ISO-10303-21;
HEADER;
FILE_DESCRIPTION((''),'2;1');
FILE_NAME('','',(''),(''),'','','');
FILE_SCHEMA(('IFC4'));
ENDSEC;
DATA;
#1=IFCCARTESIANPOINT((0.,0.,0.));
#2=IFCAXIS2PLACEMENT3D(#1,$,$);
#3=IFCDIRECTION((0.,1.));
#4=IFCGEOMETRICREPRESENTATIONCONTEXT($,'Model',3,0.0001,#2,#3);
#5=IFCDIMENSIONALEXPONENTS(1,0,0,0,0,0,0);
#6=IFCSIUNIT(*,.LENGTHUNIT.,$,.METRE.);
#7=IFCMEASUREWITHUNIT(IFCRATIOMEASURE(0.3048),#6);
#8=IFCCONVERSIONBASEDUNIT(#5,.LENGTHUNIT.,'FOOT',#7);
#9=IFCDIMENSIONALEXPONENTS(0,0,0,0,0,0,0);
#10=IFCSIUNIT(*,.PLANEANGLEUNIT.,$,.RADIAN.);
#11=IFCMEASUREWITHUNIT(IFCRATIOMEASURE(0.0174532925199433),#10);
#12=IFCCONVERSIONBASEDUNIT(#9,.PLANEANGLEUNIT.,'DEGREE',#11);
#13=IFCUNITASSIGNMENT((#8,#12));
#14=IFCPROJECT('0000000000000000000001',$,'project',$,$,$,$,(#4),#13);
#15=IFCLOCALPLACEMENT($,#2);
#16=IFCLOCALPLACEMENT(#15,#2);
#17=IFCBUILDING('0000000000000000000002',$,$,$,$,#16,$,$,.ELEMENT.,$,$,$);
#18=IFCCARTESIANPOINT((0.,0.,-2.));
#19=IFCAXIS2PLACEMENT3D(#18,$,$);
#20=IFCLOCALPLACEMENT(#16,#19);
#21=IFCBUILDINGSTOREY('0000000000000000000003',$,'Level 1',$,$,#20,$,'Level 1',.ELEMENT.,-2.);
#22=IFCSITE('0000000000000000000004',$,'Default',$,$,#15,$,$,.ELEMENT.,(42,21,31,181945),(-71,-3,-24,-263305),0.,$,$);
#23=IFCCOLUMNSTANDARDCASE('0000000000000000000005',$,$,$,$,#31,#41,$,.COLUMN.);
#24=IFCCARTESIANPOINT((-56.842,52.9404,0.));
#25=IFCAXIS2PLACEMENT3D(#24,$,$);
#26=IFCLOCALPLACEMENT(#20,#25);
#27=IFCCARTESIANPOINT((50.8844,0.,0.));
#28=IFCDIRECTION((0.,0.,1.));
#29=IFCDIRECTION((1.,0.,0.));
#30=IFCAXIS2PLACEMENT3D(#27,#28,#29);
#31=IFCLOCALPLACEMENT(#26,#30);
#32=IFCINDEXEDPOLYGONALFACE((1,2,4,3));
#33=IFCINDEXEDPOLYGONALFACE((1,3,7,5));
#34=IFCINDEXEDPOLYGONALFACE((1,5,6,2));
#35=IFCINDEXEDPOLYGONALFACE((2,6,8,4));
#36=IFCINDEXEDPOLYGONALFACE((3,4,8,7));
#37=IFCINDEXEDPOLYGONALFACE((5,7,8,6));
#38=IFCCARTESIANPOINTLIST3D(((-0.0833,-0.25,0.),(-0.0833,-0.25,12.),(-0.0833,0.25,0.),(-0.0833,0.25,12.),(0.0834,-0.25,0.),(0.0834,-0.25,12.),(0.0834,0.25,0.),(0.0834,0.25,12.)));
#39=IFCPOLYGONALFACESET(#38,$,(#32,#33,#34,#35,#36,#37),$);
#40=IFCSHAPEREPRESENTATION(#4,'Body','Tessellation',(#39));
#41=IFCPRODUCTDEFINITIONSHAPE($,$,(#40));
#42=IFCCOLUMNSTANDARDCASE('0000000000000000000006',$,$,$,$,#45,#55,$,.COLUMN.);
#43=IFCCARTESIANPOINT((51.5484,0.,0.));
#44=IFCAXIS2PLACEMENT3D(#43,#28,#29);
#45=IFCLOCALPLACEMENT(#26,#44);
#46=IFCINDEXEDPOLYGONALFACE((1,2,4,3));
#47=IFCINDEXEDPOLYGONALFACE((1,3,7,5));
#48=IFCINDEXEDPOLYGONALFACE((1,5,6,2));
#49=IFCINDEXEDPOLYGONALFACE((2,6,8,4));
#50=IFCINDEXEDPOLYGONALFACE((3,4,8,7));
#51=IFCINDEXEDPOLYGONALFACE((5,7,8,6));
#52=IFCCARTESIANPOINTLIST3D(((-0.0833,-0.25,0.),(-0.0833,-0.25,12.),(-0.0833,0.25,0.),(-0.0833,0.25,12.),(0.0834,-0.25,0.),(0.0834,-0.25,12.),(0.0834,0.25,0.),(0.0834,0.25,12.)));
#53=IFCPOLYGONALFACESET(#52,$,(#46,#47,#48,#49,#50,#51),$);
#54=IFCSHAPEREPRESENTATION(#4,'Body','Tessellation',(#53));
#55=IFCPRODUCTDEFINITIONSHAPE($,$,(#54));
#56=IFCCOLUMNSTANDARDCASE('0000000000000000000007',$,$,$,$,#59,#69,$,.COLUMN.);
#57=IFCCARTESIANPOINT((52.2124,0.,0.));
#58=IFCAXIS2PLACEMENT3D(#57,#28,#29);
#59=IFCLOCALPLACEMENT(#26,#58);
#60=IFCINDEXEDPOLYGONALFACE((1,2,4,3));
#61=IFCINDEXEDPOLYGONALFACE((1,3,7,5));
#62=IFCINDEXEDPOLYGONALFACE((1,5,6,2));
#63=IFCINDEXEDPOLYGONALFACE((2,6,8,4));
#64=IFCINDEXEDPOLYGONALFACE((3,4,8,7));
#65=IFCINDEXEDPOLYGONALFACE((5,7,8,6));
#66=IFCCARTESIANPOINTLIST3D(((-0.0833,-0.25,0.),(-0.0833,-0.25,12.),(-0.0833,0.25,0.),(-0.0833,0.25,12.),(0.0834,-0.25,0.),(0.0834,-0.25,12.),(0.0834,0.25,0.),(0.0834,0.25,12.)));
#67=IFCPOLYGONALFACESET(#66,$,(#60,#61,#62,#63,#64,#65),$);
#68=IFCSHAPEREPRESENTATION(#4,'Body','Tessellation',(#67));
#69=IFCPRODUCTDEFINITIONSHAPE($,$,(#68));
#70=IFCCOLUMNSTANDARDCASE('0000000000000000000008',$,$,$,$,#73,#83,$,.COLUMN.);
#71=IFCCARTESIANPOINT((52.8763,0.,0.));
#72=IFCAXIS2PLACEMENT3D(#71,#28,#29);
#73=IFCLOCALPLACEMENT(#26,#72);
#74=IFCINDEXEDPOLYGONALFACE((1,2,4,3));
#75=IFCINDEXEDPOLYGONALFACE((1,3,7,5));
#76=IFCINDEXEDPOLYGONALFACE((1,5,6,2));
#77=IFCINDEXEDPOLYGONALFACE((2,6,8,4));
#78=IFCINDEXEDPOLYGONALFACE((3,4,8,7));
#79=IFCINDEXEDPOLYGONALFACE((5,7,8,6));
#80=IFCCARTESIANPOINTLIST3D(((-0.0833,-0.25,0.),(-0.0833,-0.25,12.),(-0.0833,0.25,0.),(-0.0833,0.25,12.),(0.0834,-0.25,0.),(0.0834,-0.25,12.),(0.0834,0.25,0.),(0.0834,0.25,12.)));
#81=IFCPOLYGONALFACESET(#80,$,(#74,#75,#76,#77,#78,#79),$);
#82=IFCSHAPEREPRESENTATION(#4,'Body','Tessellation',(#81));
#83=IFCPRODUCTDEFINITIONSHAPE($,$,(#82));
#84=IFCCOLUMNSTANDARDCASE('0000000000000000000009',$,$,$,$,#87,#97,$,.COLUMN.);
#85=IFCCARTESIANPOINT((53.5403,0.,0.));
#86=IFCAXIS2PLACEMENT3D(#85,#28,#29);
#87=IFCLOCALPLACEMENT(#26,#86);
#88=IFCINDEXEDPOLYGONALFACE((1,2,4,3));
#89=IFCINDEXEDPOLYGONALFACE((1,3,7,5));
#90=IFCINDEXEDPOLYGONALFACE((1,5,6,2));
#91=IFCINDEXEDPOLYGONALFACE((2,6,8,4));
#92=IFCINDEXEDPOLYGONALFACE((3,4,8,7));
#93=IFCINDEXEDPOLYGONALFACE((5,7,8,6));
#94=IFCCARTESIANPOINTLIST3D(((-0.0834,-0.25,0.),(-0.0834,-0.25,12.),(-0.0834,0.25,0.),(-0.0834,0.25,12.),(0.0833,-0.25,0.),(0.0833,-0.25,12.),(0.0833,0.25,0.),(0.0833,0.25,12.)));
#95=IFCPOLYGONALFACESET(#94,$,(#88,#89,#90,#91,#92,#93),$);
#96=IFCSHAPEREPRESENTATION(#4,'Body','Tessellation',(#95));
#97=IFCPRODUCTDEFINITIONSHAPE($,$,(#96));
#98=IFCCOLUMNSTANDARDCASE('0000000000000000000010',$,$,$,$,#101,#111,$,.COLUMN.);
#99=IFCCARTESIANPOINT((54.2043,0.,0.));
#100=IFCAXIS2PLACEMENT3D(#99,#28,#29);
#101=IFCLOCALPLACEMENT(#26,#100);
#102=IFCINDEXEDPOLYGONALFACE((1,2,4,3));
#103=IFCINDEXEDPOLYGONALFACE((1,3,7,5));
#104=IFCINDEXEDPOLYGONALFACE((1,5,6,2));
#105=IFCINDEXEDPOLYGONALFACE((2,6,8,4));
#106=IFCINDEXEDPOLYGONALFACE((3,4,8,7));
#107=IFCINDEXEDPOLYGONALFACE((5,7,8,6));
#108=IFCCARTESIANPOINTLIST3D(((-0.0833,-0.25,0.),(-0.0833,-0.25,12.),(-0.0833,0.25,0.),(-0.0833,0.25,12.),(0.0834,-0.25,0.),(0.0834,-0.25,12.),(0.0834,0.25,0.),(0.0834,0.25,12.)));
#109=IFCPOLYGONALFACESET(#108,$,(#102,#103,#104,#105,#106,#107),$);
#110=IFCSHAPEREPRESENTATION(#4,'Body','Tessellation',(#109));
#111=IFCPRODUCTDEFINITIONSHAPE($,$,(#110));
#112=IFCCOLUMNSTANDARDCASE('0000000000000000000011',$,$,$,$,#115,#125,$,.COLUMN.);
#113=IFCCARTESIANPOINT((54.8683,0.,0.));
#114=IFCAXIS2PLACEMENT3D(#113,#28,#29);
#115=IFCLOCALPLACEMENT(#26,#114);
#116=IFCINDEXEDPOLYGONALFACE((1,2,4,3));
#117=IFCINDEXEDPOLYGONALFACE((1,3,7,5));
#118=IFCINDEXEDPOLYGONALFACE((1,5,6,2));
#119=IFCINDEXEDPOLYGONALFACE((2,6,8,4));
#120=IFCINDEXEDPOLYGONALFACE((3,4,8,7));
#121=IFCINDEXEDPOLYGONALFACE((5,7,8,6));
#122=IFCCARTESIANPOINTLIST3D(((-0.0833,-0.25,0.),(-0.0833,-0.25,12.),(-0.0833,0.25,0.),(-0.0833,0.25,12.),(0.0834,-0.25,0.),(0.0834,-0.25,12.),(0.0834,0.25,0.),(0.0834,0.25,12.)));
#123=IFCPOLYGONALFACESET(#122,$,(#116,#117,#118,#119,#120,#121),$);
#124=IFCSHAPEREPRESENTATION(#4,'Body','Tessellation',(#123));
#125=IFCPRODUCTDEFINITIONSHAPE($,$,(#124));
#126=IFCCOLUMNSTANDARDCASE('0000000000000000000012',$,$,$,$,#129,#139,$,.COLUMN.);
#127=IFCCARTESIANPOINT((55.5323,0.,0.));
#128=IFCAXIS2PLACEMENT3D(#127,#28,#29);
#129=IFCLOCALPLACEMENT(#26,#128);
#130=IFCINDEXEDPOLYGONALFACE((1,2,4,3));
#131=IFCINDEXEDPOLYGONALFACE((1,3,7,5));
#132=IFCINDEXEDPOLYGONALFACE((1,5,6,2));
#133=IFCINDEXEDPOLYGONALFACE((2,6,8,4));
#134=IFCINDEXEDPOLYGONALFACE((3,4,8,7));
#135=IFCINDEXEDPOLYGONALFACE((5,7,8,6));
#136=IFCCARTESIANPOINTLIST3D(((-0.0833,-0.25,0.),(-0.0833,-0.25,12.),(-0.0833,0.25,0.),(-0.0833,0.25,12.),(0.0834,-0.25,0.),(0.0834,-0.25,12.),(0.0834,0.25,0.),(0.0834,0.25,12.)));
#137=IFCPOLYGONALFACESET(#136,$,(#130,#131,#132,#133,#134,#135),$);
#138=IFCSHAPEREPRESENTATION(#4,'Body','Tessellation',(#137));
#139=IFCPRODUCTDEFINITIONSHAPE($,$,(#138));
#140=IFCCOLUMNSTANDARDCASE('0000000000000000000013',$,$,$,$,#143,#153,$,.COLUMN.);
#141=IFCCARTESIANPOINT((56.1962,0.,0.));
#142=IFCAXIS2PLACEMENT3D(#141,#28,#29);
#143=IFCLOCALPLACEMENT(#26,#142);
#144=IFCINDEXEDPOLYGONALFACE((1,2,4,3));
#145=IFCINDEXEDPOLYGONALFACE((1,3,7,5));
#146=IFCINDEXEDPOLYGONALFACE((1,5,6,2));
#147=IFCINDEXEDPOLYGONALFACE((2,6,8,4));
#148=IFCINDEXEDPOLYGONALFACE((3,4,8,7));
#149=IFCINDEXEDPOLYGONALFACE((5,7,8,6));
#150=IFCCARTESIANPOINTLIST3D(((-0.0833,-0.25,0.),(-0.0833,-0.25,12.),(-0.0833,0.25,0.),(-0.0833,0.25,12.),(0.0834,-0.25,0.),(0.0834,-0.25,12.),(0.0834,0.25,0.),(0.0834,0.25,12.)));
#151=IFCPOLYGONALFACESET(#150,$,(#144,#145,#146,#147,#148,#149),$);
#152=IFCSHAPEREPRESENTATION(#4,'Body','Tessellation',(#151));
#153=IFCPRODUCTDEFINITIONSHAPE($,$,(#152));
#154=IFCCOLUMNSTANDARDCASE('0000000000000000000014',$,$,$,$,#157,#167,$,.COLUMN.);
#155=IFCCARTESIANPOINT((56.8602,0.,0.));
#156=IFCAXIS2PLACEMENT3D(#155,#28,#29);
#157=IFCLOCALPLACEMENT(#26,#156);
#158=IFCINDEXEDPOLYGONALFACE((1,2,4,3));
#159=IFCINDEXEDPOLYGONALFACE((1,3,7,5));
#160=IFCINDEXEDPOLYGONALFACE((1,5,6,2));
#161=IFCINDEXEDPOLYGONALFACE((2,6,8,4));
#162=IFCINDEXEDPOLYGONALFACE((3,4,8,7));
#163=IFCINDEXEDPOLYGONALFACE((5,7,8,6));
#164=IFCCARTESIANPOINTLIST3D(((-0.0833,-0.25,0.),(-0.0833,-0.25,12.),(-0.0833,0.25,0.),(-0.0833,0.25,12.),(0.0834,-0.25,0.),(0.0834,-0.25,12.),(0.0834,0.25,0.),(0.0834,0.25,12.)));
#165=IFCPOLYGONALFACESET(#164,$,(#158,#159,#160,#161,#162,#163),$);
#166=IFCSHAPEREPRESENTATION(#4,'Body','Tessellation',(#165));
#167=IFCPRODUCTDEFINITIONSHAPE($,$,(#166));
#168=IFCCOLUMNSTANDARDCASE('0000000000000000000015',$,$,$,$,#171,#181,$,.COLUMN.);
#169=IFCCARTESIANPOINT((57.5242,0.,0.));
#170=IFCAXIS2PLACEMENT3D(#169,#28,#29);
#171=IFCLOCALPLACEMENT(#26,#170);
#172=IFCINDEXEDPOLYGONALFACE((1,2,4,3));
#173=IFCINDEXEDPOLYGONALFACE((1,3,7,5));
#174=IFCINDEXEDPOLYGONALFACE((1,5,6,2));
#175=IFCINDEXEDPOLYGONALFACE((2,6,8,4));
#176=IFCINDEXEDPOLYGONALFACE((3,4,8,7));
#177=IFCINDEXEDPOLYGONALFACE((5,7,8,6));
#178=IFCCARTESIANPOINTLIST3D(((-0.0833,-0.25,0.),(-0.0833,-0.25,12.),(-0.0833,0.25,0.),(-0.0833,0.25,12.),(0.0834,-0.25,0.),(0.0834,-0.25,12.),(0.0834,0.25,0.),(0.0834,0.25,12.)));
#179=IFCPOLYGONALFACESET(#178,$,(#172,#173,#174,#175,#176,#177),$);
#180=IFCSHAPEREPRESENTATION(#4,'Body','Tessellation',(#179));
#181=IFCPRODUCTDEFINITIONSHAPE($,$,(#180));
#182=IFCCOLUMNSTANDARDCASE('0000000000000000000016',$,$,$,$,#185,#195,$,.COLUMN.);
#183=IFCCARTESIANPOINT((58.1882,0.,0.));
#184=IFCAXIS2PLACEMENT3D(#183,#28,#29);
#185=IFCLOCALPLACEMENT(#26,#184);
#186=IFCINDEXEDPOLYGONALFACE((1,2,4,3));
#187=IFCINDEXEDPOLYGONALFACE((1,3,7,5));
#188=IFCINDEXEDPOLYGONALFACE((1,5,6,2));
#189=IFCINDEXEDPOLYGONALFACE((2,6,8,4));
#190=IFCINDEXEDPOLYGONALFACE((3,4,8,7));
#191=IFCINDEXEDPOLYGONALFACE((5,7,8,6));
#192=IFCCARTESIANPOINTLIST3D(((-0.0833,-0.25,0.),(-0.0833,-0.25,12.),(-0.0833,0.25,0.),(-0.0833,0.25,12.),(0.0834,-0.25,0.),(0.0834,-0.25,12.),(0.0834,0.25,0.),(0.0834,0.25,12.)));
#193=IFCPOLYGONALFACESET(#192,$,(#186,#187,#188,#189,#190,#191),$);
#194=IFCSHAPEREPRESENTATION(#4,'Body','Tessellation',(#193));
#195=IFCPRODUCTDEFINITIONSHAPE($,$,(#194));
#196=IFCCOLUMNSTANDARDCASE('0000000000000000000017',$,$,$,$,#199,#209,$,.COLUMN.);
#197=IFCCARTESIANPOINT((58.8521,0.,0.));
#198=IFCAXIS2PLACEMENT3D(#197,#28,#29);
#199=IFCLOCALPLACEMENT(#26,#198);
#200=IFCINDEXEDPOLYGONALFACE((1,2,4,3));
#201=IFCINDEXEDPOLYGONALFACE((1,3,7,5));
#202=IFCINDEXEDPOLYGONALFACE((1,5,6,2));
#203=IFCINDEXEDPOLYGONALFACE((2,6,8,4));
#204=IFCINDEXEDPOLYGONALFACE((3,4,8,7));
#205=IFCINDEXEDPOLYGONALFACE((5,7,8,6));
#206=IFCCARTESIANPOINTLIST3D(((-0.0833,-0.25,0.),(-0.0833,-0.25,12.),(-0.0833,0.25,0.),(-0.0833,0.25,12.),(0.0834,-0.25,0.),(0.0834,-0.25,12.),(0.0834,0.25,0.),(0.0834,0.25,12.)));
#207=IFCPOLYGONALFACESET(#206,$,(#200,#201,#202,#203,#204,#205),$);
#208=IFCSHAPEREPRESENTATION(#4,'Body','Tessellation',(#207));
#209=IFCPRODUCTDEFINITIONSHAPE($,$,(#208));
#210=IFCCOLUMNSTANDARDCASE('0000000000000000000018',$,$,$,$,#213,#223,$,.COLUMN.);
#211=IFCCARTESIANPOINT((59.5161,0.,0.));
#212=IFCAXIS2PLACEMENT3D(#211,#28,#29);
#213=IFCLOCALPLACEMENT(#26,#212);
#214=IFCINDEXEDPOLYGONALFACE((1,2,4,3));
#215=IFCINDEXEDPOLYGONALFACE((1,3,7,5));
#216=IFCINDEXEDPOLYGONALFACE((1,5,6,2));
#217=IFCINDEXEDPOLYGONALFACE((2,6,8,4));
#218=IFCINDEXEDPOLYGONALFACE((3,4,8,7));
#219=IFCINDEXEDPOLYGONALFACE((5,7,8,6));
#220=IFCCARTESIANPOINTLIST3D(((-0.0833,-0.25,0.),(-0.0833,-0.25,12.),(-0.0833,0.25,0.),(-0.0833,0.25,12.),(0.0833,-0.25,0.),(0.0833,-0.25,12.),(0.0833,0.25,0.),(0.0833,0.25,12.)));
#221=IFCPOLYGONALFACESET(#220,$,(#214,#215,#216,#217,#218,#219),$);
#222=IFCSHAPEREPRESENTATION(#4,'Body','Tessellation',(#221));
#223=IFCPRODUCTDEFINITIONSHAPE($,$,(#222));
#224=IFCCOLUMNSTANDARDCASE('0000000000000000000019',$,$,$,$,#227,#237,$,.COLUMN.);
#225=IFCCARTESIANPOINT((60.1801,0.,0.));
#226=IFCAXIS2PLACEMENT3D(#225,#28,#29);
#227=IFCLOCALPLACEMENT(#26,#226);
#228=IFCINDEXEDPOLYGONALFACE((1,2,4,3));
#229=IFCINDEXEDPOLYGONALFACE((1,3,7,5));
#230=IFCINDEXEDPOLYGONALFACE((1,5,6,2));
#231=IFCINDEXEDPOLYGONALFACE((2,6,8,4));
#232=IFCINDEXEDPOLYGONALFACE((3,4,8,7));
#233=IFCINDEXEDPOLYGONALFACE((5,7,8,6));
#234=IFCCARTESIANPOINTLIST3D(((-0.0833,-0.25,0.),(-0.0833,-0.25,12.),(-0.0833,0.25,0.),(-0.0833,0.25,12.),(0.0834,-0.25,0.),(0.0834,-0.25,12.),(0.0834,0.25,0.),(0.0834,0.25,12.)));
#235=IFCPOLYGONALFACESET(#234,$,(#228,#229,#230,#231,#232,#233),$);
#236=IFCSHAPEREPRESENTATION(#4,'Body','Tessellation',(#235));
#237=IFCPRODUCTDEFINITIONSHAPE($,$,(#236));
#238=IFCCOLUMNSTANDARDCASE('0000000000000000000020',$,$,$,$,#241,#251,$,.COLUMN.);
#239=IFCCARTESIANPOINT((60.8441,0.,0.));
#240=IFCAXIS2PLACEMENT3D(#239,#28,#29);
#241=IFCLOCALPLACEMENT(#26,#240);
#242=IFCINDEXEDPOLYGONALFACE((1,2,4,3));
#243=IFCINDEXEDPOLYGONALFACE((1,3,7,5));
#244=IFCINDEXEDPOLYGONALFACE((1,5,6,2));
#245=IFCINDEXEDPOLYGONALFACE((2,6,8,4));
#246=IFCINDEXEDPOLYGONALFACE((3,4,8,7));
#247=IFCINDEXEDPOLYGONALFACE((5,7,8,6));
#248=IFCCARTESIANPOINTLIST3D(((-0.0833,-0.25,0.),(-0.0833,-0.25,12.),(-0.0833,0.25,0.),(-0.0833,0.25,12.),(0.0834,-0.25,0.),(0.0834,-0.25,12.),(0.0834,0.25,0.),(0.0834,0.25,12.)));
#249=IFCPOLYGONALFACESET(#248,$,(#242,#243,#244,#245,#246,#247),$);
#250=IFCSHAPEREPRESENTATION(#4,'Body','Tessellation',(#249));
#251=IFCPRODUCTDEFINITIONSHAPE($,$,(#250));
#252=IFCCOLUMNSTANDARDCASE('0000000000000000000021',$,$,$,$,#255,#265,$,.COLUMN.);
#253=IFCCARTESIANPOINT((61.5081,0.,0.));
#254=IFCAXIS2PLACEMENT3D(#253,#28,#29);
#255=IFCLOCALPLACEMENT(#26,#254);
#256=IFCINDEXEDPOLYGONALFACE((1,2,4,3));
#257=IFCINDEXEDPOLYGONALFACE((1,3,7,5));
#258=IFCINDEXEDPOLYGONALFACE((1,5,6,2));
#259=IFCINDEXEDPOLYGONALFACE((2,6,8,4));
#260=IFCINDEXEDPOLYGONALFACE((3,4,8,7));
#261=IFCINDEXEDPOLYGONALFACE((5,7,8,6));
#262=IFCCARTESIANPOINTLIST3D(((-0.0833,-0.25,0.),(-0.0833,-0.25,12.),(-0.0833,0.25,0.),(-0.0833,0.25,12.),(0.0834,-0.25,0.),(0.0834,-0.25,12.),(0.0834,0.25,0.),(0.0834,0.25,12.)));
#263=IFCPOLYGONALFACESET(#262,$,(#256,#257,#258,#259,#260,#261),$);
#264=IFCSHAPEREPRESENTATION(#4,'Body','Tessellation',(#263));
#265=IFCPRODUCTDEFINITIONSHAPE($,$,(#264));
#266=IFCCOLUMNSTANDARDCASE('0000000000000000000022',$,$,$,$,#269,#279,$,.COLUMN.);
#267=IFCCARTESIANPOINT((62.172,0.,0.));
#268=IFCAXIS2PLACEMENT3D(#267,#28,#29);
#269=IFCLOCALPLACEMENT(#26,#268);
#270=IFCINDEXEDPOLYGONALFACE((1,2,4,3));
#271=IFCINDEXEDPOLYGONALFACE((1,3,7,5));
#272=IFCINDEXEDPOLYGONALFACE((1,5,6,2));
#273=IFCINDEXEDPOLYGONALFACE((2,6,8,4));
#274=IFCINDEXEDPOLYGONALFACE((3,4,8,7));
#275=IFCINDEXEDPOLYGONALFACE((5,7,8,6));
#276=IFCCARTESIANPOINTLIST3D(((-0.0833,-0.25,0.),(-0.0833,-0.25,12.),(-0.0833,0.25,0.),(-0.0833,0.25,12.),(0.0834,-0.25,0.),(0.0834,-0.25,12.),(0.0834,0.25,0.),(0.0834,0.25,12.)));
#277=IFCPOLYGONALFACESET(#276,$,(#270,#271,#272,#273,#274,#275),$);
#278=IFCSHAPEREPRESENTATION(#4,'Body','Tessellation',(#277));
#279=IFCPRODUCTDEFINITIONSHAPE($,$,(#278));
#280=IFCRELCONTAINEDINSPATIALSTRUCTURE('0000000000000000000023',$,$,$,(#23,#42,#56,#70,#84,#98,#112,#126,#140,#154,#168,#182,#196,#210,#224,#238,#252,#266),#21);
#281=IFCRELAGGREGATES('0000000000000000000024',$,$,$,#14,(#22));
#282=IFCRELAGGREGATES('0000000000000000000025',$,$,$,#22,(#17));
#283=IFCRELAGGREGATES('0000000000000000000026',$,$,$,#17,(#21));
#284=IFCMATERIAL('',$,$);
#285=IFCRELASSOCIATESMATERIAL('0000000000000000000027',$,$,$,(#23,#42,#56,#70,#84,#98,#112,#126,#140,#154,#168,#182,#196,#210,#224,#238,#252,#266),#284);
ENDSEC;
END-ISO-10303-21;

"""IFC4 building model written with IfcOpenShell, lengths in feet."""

from ifc_helpers import new_model, entity, si_unit, converted_unit, direction, frame, origin, place, context, project, spatial, rectangle, extrude, material, element, save


model = new_model("IFC4")

# Units and contexts
model_context = context("Model", 3, precision=0.0001, world=origin(), true_north=direction((0.0, 1.0)))
ifc_project = project(units=[converted_unit("LENGTHUNIT", "FOOT", entity("IfcRatioMeasure", 0.3048), si_unit("LENGTHUNIT", "METRE"), dimensions=[1, 0, 0, 0, 0, 0, 0]), converted_unit("PLANEANGLEUNIT", "DEGREE", entity("IfcRatioMeasure", 0.0174532925199433), si_unit("PLANEANGLEUNIT", "RADIAN"), dimensions=[0, 0, 0, 0, 0, 0, 0])], contexts=[model_context])

# Site, building, storey
site_placement = place(None, origin())
site = spatial("IfcSite", under=ifc_project, at=site_placement, Name="Default", CompositionType="ELEMENT", RefLatitude=(42, 21, 31, 181945), RefLongitude=(-71, -3, -24, -263305), RefElevation=0.0)
building_placement = place(site_placement, origin())
building = spatial("IfcBuilding", under=site, at=building_placement, CompositionType="ELEMENT")
storey_placement = place(building_placement, frame((0.0, 0.0, -2.0)))
storey = spatial("IfcBuildingStorey", under=building, at=storey_placement, Name="Level 1", LongName="Level 1", CompositionType="ELEMENT", Elevation=-2.0)

# Columns
ifc_material_1 = material(Name="")
placement_1 = place(storey_placement, frame((-56.842, 52.9404, 0.0)))
for number, where, z_axis, x_axis in (
    (1, (50.8844, 0.0, 0.0), (0.0, 0.0, 1.0), (1.0, 0.0, 0.0)),
    (2, (51.5484, 0.0, 0.0), (0.0, 0.0, 1.0), (1.0, 0.0, 0.0)),
    (3, (52.2124, 0.0, 0.0), (0.0, 0.0, 1.0), (1.0, 0.0, 0.0)),
    (4, (52.8763, 0.0, 0.0), (0.0, 0.0, 1.0), (1.0, 0.0, 0.0)),
    (5, (53.5403, 0.0, 0.0), (0.0, 0.0, 1.0), (1.0, 0.0, 0.0)),
    (6, (54.2043, 0.0, 0.0), (0.0, 0.0, 1.0), (1.0, 0.0, 0.0)),
    (7, (54.8683, 0.0, 0.0), (0.0, 0.0, 1.0), (1.0, 0.0, 0.0)),
    (8, (55.5323, 0.0, 0.0), (0.0, 0.0, 1.0), (1.0, 0.0, 0.0)),
    (9, (56.1962, 0.0, 0.0), (0.0, 0.0, 1.0), (1.0, 0.0, 0.0)),
    (10, (56.8602, 0.0, 0.0), (0.0, 0.0, 1.0), (1.0, 0.0, 0.0)),
    (11, (57.5242, 0.0, 0.0), (0.0, 0.0, 1.0), (1.0, 0.0, 0.0)),
    (12, (58.1882, 0.0, 0.0), (0.0, 0.0, 1.0), (1.0, 0.0, 0.0)),
    (13, (58.8521, 0.0, 0.0), (0.0, 0.0, 1.0), (1.0, 0.0, 0.0)),
    (14, (59.5161, 0.0, 0.0), (0.0, 0.0, 1.0), (1.0, 0.0, 0.0)),
    (15, (60.1801, 0.0, 0.0), (0.0, 0.0, 1.0), (1.0, 0.0, 0.0)),
    (16, (60.8441, 0.0, 0.0), (0.0, 0.0, 1.0), (1.0, 0.0, 0.0)),
    (17, (61.5081, 0.0, 0.0), (0.0, 0.0, 1.0), (1.0, 0.0, 0.0)),
    (18, (62.172, 0.0, 0.0), (0.0, 0.0, 1.0), (1.0, 0.0, 0.0)),
):
    element("IfcColumnStandardCase", number, at=place(placement_1, frame(where, z_axis=z_axis, x_axis=x_axis)), inside=storey, material=ifc_material_1, PredefinedType="COLUMN", context=model_context, shape_type="SweptSolid", body=[
        extrude(rectangle(XDim=0.1667, YDim=0.5), origin(), (0.0, 0.0, 1.0), 12.0),
    ])

save(model, "model.ifc")
